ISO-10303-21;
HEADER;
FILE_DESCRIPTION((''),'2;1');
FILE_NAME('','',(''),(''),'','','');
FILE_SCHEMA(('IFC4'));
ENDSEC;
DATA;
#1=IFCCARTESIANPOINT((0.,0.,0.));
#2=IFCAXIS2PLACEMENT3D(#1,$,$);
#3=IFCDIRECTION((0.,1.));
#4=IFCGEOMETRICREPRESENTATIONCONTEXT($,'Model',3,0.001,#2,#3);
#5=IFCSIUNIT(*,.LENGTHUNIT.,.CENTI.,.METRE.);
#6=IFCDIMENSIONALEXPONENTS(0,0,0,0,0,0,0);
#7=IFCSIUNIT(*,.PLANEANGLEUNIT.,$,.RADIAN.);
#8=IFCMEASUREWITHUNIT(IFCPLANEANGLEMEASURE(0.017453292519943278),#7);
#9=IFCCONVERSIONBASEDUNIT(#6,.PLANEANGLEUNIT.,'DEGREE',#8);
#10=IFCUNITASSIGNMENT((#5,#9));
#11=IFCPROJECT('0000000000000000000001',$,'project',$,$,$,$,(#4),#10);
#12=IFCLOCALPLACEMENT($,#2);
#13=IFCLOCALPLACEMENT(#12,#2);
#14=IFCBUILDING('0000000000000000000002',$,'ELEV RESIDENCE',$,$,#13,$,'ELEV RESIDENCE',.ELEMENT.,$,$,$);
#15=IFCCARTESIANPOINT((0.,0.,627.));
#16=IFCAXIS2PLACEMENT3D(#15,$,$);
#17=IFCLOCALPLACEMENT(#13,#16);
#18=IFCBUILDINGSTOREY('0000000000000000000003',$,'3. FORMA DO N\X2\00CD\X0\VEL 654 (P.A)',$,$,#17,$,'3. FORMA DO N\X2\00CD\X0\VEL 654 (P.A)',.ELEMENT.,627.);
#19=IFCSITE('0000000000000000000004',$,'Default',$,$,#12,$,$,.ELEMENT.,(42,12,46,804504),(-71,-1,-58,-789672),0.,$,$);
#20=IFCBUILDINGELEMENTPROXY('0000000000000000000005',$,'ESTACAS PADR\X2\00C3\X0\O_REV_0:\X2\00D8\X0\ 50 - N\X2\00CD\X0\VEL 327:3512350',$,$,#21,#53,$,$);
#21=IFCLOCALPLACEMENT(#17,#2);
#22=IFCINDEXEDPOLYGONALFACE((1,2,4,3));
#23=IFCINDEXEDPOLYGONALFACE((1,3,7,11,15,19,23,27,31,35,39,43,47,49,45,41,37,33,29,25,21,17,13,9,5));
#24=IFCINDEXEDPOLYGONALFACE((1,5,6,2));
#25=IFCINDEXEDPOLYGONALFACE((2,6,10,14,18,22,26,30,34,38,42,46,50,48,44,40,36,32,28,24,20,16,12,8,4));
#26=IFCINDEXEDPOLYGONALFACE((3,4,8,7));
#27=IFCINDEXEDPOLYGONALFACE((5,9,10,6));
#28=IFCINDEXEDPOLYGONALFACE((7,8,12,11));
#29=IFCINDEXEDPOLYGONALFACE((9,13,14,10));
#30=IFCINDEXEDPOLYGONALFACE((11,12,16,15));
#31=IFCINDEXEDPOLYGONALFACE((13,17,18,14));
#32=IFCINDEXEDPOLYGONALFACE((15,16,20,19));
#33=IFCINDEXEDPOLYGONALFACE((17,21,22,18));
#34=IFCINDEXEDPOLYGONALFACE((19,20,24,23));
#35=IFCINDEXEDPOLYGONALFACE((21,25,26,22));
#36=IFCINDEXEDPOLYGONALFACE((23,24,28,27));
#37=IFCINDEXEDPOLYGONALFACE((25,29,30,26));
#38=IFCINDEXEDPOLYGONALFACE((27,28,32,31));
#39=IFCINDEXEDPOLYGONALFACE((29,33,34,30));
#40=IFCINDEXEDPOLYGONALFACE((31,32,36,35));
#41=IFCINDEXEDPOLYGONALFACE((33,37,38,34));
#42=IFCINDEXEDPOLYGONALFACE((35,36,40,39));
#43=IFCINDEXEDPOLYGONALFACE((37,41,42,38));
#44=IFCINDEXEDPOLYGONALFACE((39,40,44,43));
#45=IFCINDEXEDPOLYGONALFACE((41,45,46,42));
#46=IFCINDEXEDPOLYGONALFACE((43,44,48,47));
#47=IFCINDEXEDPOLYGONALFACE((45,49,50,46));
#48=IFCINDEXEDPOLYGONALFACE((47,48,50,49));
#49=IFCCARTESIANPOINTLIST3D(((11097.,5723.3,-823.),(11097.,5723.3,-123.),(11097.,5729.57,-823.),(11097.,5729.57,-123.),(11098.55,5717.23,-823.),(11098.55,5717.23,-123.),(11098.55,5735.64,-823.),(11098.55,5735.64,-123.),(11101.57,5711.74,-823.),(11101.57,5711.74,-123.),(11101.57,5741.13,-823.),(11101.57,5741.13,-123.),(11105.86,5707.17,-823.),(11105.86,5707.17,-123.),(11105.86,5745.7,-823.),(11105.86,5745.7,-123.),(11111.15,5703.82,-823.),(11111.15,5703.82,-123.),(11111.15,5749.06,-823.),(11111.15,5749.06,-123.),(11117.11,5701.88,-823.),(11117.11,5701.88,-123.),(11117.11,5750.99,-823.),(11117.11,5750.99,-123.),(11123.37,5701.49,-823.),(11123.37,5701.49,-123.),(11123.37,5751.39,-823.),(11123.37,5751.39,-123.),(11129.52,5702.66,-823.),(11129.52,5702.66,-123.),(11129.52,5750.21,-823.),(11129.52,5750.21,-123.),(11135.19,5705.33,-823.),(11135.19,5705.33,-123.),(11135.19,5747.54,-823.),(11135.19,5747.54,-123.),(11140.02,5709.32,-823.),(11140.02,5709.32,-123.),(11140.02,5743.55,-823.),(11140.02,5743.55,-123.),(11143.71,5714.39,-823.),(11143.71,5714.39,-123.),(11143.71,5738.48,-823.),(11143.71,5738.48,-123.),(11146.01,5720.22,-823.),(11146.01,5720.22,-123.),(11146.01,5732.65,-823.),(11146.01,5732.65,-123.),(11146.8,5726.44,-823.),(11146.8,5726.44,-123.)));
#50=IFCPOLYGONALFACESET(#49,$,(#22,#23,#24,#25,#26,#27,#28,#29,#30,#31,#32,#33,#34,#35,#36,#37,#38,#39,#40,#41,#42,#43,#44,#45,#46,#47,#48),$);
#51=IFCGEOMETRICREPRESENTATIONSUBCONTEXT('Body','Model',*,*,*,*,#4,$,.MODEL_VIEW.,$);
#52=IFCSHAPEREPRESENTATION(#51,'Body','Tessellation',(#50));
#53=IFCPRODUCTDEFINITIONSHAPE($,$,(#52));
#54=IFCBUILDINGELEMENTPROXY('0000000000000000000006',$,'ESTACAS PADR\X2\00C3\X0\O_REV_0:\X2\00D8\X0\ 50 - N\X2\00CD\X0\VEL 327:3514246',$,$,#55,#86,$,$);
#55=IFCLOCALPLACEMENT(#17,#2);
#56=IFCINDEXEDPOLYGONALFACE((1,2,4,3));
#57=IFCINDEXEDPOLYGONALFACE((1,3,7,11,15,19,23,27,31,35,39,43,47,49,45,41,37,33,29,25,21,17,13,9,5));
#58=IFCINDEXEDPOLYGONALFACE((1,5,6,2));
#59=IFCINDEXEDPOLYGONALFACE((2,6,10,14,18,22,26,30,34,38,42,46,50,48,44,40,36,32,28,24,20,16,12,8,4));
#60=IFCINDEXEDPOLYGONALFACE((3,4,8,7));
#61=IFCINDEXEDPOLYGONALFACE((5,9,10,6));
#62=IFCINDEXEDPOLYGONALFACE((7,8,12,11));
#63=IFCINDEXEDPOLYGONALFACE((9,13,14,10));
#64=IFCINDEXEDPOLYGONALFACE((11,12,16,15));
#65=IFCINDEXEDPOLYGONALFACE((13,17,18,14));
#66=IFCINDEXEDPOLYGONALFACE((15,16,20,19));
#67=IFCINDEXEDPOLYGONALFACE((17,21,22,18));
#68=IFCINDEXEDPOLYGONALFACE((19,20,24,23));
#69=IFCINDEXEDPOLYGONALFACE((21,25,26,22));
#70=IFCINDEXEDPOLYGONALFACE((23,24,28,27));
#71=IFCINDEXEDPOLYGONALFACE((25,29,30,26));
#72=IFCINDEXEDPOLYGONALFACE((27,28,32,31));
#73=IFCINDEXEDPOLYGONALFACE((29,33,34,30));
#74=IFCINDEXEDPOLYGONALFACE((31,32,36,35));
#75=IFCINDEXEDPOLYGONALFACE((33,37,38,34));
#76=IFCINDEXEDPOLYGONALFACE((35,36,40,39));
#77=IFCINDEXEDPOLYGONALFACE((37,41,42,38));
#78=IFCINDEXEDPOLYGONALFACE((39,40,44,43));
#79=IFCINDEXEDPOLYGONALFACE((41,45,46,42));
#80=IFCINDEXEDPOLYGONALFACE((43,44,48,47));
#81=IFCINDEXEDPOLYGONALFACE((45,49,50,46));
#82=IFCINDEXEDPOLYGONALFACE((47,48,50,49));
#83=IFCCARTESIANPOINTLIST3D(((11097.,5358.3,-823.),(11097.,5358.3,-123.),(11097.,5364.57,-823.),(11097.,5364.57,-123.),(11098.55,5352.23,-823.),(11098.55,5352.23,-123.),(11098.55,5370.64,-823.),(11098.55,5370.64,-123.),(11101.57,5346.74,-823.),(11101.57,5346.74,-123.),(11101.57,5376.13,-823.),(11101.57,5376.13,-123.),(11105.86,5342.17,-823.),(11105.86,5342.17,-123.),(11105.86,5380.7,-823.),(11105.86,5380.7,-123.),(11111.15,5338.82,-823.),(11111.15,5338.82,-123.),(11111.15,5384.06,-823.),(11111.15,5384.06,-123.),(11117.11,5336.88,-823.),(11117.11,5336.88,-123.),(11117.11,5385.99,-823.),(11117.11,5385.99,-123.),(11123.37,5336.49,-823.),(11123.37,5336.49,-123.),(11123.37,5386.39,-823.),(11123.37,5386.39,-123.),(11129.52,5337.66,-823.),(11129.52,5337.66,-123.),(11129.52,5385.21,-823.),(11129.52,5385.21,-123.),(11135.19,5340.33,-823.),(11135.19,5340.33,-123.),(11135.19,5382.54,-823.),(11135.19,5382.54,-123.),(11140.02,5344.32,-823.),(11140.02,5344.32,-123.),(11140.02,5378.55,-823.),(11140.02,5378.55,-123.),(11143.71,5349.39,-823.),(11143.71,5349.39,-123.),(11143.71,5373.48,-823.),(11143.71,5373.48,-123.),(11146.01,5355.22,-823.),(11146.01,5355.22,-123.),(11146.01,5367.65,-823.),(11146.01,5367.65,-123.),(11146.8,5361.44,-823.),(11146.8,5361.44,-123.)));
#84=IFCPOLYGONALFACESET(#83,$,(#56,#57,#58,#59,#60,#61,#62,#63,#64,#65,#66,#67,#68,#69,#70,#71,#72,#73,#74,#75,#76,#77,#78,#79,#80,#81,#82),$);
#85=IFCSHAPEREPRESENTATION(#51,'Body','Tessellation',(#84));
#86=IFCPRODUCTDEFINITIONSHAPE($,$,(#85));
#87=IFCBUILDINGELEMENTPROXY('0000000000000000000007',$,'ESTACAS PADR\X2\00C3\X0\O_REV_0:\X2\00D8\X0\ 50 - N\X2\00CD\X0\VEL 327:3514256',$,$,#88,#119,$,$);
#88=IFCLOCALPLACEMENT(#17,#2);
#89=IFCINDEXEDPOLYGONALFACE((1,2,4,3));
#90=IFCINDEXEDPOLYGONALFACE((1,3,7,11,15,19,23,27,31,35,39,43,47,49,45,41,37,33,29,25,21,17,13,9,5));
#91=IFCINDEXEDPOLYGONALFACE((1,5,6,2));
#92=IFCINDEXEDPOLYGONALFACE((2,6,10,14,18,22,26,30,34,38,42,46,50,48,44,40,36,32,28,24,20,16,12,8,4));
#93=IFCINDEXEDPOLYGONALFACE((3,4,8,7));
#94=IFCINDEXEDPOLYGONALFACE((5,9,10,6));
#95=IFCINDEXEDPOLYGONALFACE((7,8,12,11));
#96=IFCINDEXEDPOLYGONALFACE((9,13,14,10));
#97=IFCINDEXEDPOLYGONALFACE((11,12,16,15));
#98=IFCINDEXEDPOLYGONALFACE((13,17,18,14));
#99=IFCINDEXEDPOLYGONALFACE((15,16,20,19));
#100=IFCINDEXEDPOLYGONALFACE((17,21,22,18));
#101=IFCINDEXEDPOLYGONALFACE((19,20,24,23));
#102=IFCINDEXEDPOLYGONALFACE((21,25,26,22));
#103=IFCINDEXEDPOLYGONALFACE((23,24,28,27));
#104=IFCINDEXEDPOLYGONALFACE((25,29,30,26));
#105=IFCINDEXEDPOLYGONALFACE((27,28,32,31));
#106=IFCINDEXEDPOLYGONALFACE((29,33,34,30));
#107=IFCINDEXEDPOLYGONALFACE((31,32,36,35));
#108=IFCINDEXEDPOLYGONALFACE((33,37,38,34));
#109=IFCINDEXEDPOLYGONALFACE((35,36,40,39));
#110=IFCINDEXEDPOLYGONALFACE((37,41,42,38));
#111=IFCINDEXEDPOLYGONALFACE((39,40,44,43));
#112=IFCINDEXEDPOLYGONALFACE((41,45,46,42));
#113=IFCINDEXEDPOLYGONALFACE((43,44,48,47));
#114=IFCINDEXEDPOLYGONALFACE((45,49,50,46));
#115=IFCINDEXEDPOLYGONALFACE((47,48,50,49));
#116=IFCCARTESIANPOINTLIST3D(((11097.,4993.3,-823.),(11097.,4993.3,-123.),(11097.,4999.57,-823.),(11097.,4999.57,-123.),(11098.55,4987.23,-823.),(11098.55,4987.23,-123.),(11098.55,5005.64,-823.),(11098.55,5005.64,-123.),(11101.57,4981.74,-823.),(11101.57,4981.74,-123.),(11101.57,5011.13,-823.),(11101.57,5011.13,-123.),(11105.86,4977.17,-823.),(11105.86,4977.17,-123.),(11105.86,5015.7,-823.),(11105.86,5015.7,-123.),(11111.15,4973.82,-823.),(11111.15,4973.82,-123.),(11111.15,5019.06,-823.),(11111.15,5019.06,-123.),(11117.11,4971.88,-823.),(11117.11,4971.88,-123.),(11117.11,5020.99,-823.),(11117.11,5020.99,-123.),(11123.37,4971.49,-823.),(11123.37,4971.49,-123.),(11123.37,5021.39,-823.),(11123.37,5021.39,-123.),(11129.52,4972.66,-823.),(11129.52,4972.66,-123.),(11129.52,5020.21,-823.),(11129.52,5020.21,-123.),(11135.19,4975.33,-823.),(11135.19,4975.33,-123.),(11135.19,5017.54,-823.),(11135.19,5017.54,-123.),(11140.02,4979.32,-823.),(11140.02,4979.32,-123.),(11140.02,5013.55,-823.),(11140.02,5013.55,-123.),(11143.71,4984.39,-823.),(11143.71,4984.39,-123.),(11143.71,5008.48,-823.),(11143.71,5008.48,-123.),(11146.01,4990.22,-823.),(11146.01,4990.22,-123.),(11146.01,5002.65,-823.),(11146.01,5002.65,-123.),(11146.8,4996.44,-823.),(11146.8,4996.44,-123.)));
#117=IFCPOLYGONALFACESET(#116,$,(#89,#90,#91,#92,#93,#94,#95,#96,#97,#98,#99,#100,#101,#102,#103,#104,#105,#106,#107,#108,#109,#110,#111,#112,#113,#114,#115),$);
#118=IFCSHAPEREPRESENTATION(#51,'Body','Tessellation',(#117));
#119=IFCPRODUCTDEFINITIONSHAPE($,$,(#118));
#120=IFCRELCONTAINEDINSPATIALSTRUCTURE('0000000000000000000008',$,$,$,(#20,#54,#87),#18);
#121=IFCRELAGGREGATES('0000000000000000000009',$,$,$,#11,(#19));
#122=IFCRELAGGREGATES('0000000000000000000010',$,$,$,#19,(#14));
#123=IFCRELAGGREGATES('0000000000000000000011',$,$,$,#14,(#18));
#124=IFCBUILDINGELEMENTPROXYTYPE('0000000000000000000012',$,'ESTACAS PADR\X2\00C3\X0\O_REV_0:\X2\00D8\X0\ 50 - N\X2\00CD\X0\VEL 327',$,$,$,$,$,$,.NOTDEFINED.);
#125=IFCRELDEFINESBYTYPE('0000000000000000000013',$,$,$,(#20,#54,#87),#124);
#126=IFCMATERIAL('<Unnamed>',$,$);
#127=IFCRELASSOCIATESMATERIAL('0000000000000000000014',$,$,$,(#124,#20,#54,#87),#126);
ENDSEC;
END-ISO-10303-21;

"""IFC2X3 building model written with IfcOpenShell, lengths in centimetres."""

from ifc_helpers import new_model, entity, si_unit, converted_unit, direction, frame, frame_2d, origin, place, context, subcontext, project, spatial, circle, extrude, source, transform, mapped, material, type_object, type_shapes, element, save


model = new_model("IFC2X3")

# Units and contexts
model_context = context("Model", 3, precision=0.001, world=origin(), true_north=direction((0.0, 1.0)))
body_context = subcontext(model_context, "Body", "Model", "MODEL_VIEW")
ifc_project = project(units=[si_unit("LENGTHUNIT", "METRE", prefix="CENTI"), converted_unit("PLANEANGLEUNIT", "DEGREE", entity("IfcPlaneAngleMeasure", 0.017453292519943278), si_unit("PLANEANGLEUNIT", "RADIAN"), dimensions=[0, 0, 0, 0, 0, 0, 0])], contexts=[model_context])

# Site, building, storey
site_placement = place(None, origin())
site = spatial("IfcSite", under=ifc_project, at=site_placement, Name="Default", CompositionType="ELEMENT", RefLatitude=(42, 12, 46, 804504), RefLongitude=(-71, -1, -58, -789672), RefElevation=0.0)
building_placement = place(site_placement, origin())
building = spatial("IfcBuilding", under=site, at=building_placement, Name="ELEV RESIDENCE", LongName="ELEV RESIDENCE", CompositionType="ELEMENT")
storey_placement = place(building_placement, frame((0.0, 0.0, 627.0)))
storey = spatial("IfcBuildingStorey", under=building, at=storey_placement, Name="3. FORMA DO NÍVEL 654 (P.A)", LongName="3. FORMA DO NÍVEL 654 (P.A)", CompositionType="ELEMENT", Elevation=627.0)

# Building element proxies
ifc_material_1 = material(Name="<Unnamed>")
building_element_proxy_type_1 = type_object("IfcBuildingElementProxyType", Name="ESTACAS PADRÃO_REV_0:Ø 50 - NÍVEL 327", PredefinedType="NOTDEFINED", material=ifc_material_1)
shared_shape_1 = source(origin(), body_context, "Body", "SweptSolid", [
    extrude(circle(Radius=25.0, at=frame_2d((0.0, 0.0), x_axis=(1.0, 0.0))), frame((0.0, 0.0, -820.0)), (0.0, 0.0, 1.0), 700.0),
])
type_shapes(building_element_proxy_type_1, [shared_shape_1])
for number, where, name in (
    (1, (11121.8, 5726.44, -3.0), "ESTACAS PADRÃO_REV_0:Ø 50 - NÍVEL 327:3512350"),
    (2, (11121.8, 5361.44, -3.0), "ESTACAS PADRÃO_REV_0:Ø 50 - NÍVEL 327:3514246"),
    (3, (11121.8, 4996.44, -3.0), "ESTACAS PADRÃO_REV_0:Ø 50 - NÍVEL 327:3514256"),
):
    element("IfcBuildingElementProxy", number, at=place(storey_placement, frame(where)), inside=storey, type_object=building_element_proxy_type_1, material=ifc_material_1, Name=name, context=body_context, shape_type="MappedRepresentation", body=[
        mapped(shared_shape_1, transform((0.0, 0.0, 0.0), scale=1.0)),
    ])

save(model, "model.ifc")
